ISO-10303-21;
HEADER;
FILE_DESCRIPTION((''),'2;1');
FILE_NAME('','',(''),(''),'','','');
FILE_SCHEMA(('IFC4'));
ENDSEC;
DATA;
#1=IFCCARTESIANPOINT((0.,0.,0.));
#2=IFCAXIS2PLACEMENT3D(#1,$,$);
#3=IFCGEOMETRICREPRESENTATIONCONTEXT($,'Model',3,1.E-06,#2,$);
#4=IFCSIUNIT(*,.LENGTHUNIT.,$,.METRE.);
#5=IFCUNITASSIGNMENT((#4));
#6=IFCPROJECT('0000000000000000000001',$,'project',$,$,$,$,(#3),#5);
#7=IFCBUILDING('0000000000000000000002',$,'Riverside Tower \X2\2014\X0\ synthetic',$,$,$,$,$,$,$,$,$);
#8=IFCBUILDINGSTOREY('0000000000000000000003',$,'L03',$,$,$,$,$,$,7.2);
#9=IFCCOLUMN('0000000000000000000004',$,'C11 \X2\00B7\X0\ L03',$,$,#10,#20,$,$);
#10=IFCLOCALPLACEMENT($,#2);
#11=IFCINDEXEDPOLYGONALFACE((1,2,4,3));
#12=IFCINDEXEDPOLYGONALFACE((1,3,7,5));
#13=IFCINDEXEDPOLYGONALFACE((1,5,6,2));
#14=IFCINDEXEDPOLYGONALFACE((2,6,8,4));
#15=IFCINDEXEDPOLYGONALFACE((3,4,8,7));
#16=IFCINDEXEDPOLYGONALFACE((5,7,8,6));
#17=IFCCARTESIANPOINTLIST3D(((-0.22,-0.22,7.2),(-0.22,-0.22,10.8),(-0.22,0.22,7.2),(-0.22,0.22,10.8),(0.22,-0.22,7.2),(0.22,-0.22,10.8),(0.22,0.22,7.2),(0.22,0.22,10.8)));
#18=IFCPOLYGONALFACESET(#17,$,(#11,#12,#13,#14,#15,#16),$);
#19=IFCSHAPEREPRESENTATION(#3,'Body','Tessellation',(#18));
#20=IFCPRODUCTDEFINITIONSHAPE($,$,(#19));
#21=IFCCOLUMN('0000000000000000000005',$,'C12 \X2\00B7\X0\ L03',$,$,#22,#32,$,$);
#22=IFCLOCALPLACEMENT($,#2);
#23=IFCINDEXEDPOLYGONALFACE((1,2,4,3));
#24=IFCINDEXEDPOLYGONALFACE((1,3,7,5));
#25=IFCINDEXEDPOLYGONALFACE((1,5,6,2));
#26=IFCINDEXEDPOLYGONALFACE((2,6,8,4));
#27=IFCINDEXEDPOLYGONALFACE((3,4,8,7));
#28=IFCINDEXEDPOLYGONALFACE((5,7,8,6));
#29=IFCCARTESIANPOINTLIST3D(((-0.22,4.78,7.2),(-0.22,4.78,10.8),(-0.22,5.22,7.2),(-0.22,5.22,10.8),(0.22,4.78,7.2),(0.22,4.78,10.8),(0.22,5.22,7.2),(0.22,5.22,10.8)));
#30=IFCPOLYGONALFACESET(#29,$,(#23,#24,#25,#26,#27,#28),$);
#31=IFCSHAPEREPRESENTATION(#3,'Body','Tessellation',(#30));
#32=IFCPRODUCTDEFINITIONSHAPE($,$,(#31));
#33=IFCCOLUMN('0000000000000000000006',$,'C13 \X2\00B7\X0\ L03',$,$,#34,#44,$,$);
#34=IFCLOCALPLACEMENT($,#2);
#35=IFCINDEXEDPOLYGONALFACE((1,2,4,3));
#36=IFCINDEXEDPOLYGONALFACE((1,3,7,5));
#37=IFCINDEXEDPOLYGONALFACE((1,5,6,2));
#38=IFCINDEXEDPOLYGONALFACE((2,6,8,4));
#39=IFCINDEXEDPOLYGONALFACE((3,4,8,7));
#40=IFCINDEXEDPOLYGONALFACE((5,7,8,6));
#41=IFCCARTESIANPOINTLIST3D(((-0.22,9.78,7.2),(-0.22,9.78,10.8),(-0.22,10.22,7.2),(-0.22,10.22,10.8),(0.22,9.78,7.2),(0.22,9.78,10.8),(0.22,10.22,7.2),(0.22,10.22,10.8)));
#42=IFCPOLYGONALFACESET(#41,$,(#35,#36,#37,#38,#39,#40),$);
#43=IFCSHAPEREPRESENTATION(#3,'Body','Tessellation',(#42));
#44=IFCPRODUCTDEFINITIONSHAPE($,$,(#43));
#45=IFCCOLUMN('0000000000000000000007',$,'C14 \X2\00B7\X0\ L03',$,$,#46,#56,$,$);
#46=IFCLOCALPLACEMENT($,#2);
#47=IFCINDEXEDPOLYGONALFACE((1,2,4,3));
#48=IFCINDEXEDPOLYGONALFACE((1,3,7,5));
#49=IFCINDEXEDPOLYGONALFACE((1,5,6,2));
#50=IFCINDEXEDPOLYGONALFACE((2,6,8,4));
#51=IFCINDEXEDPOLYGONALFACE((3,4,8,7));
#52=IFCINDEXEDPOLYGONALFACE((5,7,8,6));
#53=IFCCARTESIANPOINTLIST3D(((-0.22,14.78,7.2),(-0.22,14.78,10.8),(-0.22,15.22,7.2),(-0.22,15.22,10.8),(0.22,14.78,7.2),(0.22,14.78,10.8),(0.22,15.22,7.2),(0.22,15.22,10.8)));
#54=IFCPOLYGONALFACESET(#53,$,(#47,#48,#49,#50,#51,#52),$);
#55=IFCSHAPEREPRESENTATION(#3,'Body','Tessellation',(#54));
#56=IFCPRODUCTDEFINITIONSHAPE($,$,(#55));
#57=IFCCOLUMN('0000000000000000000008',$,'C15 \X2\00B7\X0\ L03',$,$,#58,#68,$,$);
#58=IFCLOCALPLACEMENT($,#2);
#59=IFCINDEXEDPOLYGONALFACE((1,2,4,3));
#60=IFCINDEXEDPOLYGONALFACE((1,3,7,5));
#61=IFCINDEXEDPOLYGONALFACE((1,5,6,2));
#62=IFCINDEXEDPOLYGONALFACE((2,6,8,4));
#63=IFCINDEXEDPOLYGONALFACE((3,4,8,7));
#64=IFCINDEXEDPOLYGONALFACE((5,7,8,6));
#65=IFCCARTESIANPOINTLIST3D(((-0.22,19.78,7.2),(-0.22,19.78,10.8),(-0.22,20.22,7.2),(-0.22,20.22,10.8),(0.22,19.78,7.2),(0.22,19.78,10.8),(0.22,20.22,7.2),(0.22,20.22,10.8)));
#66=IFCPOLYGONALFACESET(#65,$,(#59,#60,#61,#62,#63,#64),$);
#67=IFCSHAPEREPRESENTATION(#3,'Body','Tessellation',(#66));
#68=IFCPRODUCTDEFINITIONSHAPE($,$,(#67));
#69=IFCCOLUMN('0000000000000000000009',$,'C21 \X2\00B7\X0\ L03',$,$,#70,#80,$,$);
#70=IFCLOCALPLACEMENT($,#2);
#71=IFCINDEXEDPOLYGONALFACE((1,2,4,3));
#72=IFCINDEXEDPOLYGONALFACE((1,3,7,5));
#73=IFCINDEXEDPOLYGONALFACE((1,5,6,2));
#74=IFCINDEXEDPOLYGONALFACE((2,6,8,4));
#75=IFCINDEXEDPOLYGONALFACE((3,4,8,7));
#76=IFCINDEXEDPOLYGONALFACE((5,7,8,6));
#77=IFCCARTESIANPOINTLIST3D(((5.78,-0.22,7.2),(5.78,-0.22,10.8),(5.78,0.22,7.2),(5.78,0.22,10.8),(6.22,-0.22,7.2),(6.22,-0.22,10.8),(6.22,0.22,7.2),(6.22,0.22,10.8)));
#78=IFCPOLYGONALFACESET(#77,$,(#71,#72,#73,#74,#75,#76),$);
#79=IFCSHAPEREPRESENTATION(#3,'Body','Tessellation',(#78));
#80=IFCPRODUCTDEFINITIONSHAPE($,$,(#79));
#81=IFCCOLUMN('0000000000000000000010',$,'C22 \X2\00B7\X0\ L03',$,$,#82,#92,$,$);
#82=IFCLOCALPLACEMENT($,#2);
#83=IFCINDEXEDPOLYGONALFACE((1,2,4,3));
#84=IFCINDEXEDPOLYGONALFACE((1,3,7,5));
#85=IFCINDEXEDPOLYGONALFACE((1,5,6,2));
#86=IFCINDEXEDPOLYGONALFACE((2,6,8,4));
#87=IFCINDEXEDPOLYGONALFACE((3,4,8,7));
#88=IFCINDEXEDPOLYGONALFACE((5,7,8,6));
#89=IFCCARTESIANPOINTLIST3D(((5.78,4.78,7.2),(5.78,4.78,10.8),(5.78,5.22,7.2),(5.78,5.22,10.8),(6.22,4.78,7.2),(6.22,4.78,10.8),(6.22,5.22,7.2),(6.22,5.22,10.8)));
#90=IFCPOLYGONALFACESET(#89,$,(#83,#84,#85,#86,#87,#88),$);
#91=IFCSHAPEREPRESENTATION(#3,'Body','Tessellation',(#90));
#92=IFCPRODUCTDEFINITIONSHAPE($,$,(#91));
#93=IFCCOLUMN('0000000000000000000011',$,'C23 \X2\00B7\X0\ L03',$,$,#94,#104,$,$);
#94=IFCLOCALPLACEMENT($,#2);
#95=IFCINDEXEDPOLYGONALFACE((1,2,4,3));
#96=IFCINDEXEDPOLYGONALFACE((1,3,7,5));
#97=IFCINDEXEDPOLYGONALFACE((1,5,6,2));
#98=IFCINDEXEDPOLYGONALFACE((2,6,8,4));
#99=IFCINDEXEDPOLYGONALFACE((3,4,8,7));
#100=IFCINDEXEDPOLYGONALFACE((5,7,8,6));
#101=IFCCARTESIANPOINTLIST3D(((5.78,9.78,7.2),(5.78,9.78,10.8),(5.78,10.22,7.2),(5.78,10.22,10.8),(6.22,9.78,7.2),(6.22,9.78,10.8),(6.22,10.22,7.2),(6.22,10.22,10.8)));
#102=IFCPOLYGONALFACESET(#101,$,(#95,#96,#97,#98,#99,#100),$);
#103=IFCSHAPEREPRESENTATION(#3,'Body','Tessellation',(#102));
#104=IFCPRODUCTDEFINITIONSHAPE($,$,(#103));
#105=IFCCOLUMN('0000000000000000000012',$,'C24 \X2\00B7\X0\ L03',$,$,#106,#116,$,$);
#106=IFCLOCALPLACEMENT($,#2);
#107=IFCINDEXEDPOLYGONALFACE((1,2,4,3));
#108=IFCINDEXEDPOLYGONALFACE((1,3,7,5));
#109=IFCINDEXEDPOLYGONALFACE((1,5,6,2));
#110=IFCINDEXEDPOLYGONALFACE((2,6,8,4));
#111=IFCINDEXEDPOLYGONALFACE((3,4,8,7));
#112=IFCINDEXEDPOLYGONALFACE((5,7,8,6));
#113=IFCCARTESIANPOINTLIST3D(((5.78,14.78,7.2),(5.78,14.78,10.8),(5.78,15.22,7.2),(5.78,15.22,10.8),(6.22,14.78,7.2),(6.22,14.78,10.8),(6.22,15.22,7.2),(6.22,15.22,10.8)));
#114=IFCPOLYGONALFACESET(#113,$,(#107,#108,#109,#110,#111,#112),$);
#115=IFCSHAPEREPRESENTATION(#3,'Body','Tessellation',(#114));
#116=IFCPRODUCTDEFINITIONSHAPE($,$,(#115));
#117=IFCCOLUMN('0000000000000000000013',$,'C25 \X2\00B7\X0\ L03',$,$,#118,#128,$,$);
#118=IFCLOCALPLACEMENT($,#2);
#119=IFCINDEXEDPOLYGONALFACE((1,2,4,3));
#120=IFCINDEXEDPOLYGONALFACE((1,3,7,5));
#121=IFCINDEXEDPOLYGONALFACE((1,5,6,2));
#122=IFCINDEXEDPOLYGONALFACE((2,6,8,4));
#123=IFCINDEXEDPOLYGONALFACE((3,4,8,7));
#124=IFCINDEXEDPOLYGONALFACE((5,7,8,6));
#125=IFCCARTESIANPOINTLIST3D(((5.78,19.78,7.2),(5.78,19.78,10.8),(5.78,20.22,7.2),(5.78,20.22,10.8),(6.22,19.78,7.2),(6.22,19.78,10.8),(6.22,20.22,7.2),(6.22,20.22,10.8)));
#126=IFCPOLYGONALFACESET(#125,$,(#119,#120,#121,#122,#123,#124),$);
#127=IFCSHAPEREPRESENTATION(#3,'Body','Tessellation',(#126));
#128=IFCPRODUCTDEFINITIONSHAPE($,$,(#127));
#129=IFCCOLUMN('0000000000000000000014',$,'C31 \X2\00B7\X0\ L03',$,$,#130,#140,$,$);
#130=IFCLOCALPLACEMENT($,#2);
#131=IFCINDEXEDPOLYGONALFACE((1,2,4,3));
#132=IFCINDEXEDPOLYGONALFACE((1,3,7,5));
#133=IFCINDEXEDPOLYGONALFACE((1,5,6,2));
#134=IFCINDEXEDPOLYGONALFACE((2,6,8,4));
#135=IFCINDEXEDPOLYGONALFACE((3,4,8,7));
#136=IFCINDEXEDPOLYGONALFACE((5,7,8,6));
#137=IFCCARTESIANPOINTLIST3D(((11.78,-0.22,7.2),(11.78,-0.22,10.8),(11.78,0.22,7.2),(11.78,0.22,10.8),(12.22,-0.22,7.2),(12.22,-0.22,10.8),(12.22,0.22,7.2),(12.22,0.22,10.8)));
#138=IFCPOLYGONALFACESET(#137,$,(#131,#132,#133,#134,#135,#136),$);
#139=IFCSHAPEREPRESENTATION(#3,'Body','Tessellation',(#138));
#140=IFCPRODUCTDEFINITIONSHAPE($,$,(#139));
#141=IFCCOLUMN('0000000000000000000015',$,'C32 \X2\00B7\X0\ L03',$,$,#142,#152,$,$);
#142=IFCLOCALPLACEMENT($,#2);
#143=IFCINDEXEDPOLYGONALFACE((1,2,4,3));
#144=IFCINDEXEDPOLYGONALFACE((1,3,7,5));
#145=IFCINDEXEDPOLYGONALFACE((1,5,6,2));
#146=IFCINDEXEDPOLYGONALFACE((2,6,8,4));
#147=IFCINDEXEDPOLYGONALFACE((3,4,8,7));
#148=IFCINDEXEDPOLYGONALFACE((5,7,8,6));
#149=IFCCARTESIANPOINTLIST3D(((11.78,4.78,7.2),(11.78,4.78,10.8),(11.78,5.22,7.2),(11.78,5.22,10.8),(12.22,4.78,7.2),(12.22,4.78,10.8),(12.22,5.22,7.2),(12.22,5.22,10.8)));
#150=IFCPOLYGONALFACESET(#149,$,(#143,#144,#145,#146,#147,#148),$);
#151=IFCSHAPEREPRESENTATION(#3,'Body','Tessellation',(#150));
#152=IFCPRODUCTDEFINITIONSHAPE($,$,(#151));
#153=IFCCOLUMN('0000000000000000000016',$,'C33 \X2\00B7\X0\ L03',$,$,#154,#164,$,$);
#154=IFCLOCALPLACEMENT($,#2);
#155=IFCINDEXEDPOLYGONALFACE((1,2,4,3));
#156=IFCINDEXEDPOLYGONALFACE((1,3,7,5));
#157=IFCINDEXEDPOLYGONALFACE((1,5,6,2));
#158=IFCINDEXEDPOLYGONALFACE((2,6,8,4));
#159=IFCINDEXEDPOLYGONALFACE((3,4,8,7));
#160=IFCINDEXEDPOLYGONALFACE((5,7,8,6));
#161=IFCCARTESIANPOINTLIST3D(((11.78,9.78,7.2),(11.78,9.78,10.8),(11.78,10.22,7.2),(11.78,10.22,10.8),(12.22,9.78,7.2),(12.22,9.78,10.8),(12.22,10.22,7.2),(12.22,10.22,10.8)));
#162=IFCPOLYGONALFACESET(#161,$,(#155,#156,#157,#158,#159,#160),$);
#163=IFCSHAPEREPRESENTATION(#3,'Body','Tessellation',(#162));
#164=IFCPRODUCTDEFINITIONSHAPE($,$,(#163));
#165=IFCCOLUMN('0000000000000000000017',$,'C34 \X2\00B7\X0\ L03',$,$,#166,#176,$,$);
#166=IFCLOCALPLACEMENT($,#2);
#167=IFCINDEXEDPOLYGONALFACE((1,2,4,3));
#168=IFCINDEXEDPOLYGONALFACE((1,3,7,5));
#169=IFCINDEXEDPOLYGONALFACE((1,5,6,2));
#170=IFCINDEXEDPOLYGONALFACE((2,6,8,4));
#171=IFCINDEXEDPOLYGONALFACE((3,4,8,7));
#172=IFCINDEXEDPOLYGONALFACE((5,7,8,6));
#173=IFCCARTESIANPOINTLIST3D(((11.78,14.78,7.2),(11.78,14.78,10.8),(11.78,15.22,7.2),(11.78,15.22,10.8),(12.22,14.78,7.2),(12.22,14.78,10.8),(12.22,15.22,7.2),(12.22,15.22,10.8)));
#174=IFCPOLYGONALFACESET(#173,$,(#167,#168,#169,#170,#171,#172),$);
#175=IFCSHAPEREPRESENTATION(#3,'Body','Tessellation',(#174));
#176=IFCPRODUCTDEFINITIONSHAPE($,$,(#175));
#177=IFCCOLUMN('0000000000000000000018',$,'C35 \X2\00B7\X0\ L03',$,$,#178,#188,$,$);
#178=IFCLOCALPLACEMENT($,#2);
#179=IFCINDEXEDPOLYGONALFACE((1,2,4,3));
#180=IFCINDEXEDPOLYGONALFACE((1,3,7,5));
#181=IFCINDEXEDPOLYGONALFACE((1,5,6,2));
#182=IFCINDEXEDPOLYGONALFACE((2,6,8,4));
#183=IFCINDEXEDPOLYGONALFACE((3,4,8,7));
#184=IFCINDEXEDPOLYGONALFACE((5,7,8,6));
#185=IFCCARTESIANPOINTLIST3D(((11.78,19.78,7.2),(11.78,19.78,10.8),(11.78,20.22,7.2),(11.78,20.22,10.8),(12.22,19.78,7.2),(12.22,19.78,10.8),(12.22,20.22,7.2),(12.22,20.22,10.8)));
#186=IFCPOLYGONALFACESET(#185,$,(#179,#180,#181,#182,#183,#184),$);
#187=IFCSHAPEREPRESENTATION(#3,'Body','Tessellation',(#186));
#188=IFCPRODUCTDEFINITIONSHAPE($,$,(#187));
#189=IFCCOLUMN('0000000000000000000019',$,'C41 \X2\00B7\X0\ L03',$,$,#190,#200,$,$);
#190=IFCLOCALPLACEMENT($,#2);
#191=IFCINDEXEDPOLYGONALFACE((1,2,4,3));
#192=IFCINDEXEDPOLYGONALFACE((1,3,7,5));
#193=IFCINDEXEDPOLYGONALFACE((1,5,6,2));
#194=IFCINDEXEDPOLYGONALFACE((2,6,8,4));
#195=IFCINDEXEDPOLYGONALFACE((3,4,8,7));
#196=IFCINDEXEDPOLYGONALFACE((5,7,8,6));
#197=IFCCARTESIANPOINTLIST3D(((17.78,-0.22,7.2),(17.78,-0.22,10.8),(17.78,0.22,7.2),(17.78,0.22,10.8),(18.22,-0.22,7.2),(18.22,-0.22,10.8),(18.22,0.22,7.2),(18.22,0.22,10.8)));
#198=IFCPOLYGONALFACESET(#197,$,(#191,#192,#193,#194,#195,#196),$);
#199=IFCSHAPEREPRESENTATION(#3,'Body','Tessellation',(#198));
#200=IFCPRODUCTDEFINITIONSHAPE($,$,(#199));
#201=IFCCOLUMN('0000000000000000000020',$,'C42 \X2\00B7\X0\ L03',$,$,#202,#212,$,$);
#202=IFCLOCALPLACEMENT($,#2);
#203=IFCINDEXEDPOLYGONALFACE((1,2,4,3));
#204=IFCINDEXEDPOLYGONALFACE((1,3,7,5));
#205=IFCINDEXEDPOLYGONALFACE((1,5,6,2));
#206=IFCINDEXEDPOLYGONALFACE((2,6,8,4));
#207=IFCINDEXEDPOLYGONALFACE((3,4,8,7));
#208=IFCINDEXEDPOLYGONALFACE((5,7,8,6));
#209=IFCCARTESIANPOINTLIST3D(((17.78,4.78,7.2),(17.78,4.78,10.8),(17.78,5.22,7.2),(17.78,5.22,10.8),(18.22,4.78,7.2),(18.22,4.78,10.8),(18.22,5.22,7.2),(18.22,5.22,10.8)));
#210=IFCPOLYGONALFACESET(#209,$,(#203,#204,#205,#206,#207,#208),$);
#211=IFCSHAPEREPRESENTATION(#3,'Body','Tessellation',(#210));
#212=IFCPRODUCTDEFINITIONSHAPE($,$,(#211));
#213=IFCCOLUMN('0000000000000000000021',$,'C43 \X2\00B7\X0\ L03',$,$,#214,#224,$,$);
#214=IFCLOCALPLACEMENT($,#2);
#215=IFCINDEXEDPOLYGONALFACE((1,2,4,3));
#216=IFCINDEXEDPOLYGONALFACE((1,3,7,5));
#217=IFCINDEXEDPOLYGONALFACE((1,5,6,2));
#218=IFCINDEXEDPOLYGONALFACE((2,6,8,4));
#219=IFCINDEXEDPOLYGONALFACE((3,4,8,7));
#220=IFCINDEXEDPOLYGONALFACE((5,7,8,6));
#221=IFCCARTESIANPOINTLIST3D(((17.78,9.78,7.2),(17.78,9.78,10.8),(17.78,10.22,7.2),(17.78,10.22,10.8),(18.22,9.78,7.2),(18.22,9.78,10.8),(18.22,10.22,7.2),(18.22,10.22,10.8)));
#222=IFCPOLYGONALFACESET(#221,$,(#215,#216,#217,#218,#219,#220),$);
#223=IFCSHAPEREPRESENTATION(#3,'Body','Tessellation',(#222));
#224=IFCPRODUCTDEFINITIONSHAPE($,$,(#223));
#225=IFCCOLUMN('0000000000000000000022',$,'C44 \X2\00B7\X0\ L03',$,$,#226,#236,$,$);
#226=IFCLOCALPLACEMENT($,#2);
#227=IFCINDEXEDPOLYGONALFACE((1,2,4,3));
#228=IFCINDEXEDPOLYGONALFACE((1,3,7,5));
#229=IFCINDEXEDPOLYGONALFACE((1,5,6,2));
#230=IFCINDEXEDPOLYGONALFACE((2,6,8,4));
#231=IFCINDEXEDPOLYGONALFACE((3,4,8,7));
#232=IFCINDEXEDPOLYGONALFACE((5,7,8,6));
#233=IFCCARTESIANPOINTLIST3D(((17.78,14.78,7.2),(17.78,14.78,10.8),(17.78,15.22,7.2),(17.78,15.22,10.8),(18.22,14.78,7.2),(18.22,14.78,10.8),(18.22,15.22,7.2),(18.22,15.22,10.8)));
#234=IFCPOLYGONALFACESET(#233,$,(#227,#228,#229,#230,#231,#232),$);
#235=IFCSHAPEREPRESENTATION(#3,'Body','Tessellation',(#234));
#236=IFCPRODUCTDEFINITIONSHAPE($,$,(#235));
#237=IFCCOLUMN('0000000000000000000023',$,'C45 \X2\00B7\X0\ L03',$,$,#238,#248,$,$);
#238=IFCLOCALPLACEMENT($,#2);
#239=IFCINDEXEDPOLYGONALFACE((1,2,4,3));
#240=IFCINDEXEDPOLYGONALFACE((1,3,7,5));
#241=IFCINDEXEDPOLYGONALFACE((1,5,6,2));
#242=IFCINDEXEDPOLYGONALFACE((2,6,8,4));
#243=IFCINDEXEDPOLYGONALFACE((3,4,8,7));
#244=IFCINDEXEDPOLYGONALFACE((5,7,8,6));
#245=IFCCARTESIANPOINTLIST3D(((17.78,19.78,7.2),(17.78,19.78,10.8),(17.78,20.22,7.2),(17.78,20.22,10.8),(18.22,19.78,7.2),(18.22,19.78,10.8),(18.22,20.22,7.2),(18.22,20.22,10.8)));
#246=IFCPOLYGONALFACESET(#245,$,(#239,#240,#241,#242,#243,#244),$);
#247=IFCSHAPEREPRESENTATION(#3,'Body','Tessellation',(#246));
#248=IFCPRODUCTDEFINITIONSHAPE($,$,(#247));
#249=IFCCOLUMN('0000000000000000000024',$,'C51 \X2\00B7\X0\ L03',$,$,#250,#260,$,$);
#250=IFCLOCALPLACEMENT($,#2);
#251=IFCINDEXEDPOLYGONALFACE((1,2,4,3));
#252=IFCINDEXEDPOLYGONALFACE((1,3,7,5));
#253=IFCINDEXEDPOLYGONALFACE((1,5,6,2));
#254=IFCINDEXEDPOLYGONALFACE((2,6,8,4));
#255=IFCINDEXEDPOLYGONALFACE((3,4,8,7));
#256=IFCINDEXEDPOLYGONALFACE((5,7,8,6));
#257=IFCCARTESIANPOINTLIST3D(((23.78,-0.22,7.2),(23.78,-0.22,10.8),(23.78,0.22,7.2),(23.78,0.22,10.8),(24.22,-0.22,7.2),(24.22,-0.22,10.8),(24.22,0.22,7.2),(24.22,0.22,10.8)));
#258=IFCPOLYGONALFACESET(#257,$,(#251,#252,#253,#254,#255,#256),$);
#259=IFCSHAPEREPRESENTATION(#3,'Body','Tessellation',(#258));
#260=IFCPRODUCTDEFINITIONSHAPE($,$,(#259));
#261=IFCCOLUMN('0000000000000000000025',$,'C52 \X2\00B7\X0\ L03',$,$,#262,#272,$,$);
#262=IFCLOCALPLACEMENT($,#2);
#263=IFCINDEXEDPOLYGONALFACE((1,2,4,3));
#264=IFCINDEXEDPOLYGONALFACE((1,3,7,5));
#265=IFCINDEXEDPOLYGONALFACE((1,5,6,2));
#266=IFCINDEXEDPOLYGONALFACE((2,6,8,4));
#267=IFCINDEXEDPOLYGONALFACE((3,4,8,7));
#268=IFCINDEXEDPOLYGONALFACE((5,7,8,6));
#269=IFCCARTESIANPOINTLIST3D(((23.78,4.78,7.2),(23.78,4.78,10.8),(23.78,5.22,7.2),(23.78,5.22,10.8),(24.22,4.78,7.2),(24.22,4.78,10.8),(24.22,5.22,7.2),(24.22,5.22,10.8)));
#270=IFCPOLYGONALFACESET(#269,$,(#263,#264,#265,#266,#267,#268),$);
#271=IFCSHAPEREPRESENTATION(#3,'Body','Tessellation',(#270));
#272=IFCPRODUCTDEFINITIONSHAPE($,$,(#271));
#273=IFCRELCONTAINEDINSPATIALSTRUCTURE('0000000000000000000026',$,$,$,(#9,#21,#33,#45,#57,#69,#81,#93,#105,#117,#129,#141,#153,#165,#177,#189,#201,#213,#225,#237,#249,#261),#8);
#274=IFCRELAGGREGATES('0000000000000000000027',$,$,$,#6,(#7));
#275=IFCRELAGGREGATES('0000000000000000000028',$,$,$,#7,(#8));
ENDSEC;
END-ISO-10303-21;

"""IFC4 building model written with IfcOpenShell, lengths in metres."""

from ifc_helpers import new_model, si_unit, frame, origin, place, context, project, spatial, rectangle, extrude, element, save


model = new_model("IFC4")

# Units and contexts
model_context = context("Model", 3, precision=1e-06, world=origin())
ifc_project = project(units=[si_unit("LENGTHUNIT", "METRE")], contexts=[model_context])

# Building, storey
building = spatial("IfcBuilding", under=ifc_project, Name="Riverside Tower — synthetic")
storey = spatial("IfcBuildingStorey", under=building, Name="L03", Elevation=7.2)

# Columns
for number, where, name in (
    (1, (0.0, 0.0, 7.2), "C11 · L03"),
    (2, (0.0, 5.0, 7.2), "C12 · L03"),
    (3, (0.0, 10.0, 7.2), "C13 · L03"),
    (4, (0.0, 15.0, 7.2), "C14 · L03"),
    (5, (0.0, 20.0, 7.2), "C15 · L03"),
    (6, (6.0, 0.0, 7.2), "C21 · L03"),
    (7, (6.0, 5.0, 7.2), "C22 · L03"),
    (8, (6.0, 10.0, 7.2), "C23 · L03"),
    (9, (6.0, 15.0, 7.2), "C24 · L03"),
    (10, (6.0, 20.0, 7.2), "C25 · L03"),
    (11, (12.0, 0.0, 7.2), "C31 · L03"),
    (12, (12.0, 5.0, 7.2), "C32 · L03"),
    (13, (12.0, 10.0, 7.2), "C33 · L03"),
    (14, (12.0, 15.0, 7.2), "C34 · L03"),
    (15, (12.0, 20.0, 7.2), "C35 · L03"),
    (16, (18.0, 0.0, 7.2), "C41 · L03"),
    (17, (18.0, 5.0, 7.2), "C42 · L03"),
    (18, (18.0, 10.0, 7.2), "C43 · L03"),
    (19, (18.0, 15.0, 7.2), "C44 · L03"),
    (20, (18.0, 20.0, 7.2), "C45 · L03"),
    (21, (24.0, 0.0, 7.2), "C51 · L03"),
    (22, (24.0, 5.0, 7.2), "C52 · L03"),
):
    element("IfcColumn", number, at=place(None, frame(where)), inside=storey, Name=name, context=model_context, shape_type="SweptSolid", body=[
        extrude(rectangle(XDim=0.44, YDim=0.44), origin(), (0.0, 0.0, 1.0), 3.6),
    ])

save(model, "model.ifc")
